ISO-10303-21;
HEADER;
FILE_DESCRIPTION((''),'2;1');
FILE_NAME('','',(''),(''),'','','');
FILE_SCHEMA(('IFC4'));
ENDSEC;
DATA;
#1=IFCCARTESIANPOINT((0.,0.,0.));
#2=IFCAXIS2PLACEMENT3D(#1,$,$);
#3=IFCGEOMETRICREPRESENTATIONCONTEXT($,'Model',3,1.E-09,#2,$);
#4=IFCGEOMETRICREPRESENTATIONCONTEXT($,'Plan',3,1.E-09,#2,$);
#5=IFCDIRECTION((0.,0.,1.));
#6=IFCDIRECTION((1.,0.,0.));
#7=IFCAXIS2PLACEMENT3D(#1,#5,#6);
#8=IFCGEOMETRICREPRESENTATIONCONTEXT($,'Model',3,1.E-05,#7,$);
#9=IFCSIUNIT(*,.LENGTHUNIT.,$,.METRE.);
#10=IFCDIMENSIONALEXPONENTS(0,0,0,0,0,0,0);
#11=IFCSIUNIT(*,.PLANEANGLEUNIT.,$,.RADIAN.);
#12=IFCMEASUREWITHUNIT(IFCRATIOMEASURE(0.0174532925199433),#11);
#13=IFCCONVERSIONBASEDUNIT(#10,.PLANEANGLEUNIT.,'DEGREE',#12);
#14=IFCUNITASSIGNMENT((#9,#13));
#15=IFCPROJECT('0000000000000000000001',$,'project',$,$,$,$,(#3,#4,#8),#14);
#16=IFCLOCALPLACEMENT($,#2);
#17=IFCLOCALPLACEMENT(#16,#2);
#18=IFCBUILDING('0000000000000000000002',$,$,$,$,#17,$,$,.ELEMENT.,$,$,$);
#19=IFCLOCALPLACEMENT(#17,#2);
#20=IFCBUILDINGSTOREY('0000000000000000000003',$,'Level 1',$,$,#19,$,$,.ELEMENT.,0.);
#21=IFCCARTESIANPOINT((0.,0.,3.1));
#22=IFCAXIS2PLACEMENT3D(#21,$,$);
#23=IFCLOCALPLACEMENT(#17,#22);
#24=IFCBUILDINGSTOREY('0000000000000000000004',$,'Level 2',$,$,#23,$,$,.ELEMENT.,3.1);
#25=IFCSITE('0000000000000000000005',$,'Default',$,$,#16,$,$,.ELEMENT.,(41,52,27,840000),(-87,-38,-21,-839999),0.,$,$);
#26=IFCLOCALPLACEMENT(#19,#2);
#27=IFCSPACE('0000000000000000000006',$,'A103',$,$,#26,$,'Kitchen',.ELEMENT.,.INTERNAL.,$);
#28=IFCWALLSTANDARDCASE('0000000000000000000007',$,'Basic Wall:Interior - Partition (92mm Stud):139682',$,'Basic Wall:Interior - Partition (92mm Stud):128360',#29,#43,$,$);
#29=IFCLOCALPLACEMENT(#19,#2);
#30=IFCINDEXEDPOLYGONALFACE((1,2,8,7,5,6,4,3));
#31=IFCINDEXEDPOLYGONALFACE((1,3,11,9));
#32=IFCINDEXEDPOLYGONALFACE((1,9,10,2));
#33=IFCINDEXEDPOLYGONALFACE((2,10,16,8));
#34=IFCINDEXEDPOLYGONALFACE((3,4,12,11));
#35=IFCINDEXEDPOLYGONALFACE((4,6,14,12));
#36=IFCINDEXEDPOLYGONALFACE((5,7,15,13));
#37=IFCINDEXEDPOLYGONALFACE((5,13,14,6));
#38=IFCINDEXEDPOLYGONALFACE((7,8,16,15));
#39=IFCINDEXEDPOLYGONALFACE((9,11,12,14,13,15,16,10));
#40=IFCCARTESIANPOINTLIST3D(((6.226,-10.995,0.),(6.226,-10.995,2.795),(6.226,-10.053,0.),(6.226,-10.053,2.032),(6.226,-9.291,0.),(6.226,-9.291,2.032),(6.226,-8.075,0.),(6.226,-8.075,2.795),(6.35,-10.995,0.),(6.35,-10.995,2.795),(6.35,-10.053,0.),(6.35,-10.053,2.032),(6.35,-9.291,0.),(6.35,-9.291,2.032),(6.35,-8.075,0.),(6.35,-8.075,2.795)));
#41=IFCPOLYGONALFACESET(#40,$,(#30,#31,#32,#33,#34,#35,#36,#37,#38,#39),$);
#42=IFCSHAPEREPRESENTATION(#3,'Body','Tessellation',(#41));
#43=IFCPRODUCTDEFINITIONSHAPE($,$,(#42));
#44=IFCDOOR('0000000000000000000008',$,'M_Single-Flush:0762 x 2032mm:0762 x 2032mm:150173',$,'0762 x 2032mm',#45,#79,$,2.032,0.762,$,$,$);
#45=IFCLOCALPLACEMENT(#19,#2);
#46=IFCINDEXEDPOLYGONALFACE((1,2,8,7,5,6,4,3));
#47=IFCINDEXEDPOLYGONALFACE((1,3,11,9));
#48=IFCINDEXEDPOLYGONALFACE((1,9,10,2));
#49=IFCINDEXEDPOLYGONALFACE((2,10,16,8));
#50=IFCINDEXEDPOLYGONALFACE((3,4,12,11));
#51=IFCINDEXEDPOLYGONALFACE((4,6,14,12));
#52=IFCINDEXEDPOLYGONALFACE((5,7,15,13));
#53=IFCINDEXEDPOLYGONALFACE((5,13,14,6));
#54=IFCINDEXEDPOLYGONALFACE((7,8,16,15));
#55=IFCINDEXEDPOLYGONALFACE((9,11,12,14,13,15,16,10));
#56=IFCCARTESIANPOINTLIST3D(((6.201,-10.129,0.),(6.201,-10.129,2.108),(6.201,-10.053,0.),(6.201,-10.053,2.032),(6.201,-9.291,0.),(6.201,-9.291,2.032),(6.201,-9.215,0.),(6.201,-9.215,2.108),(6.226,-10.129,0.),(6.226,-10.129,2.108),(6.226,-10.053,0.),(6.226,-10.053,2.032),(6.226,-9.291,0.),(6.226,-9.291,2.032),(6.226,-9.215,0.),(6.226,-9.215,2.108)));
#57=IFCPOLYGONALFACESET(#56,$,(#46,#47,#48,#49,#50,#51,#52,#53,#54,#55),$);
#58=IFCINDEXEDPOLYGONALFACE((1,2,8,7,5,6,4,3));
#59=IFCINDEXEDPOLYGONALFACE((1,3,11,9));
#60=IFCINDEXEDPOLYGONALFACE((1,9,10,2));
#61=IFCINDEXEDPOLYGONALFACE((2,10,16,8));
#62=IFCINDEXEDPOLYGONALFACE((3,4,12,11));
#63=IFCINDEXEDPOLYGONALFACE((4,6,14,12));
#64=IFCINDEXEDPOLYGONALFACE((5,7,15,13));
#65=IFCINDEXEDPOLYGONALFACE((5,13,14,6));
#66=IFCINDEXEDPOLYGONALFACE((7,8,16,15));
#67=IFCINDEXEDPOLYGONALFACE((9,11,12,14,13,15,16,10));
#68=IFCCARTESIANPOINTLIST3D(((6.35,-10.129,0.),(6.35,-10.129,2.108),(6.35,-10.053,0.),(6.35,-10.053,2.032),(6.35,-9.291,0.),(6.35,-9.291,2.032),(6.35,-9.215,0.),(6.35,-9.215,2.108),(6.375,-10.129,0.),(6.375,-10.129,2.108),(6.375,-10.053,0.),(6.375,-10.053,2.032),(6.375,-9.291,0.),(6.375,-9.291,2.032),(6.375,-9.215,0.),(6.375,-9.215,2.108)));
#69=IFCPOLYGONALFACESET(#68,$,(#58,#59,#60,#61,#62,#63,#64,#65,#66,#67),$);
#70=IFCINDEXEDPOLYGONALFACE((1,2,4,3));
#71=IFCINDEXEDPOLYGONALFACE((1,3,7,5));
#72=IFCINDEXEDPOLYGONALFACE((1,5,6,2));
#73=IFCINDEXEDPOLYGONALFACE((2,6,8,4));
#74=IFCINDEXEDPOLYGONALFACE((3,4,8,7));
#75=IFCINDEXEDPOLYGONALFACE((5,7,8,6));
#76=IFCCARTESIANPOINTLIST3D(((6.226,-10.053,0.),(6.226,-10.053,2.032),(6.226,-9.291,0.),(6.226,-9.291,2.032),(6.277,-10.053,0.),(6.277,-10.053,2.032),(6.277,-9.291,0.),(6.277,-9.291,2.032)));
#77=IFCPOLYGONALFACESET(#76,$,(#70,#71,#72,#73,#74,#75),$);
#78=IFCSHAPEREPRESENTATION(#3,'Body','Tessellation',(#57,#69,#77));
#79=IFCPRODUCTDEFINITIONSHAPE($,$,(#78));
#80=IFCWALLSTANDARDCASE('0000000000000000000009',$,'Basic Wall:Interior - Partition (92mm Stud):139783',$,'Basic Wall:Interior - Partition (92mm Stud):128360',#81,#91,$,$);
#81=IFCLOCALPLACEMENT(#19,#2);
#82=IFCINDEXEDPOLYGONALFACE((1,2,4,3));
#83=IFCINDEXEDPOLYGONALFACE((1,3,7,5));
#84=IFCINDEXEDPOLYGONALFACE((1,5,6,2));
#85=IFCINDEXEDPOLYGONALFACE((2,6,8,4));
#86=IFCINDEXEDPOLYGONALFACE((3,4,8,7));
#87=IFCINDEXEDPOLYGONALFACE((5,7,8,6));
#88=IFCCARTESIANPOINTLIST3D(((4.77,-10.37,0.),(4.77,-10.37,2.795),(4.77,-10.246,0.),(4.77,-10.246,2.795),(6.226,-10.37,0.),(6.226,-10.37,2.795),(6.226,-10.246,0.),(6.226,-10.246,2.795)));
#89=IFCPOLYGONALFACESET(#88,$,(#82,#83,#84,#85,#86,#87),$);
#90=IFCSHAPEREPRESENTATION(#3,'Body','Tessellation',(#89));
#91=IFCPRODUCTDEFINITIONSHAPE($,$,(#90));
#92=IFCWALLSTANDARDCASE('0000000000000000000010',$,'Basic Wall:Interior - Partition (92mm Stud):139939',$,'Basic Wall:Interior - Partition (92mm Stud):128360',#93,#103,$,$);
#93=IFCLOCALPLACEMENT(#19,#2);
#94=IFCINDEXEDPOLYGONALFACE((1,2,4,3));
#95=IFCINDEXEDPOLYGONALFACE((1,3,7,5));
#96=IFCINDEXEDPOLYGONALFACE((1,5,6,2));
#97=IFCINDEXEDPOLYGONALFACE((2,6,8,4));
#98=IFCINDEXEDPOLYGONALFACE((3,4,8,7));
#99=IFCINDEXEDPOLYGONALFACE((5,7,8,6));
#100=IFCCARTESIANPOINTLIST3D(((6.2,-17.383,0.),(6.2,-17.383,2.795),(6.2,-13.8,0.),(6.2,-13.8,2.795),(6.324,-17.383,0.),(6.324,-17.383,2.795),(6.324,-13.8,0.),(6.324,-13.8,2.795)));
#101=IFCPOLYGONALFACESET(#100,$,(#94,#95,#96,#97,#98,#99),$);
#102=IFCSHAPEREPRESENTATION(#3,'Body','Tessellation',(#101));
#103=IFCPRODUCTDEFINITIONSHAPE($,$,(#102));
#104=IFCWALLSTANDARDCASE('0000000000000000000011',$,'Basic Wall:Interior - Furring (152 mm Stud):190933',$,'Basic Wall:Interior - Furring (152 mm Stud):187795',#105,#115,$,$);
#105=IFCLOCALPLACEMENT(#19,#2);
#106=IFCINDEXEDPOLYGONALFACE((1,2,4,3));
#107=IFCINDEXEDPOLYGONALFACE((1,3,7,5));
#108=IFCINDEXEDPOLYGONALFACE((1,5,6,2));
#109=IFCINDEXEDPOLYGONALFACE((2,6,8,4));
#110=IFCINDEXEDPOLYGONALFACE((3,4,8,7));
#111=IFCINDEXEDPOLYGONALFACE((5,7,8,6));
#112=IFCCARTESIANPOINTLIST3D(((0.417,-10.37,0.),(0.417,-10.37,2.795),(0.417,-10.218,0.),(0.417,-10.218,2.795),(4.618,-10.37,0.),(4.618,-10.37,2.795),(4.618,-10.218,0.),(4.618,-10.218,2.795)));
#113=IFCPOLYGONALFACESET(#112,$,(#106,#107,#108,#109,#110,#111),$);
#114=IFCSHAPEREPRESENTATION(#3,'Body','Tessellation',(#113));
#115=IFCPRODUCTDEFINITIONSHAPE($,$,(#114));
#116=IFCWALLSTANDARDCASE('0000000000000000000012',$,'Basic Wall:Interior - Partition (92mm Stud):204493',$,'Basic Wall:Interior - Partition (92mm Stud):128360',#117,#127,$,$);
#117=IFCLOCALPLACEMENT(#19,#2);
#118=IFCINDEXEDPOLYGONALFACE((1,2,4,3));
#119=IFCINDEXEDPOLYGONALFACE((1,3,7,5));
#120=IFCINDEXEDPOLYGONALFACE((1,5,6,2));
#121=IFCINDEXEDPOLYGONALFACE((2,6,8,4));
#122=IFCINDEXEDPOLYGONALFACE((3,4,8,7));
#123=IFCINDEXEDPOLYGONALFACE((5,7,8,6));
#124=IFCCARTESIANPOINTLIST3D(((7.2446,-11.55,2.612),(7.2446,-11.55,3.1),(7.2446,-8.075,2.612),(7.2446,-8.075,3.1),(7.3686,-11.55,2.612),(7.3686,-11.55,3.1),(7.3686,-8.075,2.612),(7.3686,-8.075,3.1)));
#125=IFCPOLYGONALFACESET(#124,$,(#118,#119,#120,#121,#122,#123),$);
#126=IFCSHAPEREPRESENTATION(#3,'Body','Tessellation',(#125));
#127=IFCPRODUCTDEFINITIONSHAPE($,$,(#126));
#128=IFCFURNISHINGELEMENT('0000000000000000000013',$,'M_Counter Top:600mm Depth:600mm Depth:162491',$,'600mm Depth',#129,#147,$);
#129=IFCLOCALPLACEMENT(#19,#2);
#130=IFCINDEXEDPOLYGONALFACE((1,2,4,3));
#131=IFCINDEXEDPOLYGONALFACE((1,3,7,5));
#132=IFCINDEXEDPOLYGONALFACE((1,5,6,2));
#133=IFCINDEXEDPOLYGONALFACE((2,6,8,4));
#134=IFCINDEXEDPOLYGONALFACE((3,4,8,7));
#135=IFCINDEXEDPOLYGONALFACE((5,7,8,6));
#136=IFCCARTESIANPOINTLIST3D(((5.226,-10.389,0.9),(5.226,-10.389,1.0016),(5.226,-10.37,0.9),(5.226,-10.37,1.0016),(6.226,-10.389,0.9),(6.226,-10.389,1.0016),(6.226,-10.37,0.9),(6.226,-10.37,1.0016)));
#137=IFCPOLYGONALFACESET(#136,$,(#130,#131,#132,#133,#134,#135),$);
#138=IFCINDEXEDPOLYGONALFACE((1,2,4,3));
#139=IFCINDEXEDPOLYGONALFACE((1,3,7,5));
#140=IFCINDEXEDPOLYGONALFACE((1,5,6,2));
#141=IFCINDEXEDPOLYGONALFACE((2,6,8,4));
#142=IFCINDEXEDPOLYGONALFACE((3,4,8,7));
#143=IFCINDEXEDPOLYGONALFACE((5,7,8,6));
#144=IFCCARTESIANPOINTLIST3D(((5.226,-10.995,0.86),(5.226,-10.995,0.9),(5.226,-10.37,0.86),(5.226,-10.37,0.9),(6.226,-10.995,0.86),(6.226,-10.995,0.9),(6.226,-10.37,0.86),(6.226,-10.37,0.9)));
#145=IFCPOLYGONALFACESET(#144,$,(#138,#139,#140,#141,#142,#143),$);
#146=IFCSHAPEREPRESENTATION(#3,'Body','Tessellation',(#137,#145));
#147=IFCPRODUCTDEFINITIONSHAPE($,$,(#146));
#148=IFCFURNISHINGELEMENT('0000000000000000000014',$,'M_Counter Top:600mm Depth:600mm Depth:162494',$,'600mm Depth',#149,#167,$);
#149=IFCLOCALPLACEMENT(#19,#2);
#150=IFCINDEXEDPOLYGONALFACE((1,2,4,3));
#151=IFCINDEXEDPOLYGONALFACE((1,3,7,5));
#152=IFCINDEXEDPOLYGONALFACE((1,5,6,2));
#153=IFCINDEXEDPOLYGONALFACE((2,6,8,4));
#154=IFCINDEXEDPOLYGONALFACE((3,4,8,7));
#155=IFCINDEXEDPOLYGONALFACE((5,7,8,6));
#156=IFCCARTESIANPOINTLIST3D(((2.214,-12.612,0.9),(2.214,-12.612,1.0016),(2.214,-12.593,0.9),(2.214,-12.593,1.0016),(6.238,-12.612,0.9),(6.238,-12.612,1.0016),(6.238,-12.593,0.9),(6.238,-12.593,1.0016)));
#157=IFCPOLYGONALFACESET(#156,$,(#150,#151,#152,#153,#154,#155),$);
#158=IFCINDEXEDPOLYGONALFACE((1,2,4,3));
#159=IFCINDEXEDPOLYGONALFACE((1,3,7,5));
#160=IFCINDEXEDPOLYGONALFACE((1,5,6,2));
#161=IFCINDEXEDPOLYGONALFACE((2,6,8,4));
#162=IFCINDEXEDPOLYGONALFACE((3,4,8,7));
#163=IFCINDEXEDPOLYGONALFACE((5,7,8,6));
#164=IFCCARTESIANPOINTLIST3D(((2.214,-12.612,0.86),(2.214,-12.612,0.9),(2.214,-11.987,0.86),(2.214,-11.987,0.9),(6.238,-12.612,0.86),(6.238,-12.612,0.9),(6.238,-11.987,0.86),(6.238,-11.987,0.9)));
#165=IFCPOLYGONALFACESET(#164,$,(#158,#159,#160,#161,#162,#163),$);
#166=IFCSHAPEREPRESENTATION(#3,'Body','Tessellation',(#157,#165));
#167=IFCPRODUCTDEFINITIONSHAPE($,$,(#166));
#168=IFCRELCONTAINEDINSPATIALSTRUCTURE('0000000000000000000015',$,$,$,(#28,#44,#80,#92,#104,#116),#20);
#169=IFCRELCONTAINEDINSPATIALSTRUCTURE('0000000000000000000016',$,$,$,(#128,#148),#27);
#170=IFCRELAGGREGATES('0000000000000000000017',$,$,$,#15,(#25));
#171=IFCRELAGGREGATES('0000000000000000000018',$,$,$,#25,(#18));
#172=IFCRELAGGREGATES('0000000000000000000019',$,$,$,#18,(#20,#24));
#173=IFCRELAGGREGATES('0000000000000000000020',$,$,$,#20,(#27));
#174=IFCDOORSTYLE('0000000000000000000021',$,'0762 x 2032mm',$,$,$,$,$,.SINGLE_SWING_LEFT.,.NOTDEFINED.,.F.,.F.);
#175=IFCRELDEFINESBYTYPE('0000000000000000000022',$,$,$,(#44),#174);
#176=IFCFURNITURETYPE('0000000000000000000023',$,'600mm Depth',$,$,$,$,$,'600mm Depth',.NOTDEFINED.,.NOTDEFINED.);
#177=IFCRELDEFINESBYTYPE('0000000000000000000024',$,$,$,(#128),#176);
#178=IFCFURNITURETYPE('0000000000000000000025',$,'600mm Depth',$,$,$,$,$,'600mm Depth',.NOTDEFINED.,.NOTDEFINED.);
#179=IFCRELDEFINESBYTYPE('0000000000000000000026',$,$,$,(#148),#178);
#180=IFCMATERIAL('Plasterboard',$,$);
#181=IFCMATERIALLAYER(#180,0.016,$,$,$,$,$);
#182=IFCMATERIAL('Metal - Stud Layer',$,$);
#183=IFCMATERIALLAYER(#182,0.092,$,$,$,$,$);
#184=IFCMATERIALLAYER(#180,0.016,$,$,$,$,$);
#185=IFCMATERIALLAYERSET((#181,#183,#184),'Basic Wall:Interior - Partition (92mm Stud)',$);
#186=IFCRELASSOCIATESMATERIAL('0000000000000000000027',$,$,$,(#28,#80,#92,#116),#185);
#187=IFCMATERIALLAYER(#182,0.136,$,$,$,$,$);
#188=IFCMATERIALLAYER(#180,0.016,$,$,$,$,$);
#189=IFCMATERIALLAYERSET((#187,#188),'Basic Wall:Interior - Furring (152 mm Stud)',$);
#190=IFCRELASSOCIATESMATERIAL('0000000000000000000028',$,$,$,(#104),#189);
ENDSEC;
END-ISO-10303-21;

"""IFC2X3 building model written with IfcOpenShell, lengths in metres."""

from ifc_helpers import new_model, entity, si_unit, converted_unit, frame, frame_2d, origin, origin_with_axes, origin_2d_with_axis, place, context, project, spatial, polyline, rectangle, outline, extrude, source, transform, mapped, material, layer, layer_set, layer_usage, type_object, type_shapes, element, fill, save


model = new_model("IFC2X3")

# Units and contexts
model_context_1 = context("Model", 3, precision=1e-09, world=origin())
plan_context = context("Plan", 3, precision=1e-09, world=origin())
model_context_2 = context("Model", 3, precision=1e-05, world=origin_with_axes())
ifc_project = project(units=[si_unit("LENGTHUNIT", "METRE"), converted_unit("PLANEANGLEUNIT", "DEGREE", entity("IfcRatioMeasure", 0.0174532925199433), si_unit("PLANEANGLEUNIT", "RADIAN"), dimensions=[0, 0, 0, 0, 0, 0, 0])], contexts=[model_context_1, plan_context, model_context_2])

# Site, building, storey
site_placement = place(None, origin())
site = spatial("IfcSite", under=ifc_project, at=site_placement, Name="Default", CompositionType="ELEMENT", RefLatitude=(41, 52, 27, 840000), RefLongitude=(-87, -38, -21, -839999), RefElevation=0.0)
building_placement = place(site_placement, origin())
building = spatial("IfcBuilding", under=site, at=building_placement, CompositionType="ELEMENT")
storey_1_placement = place(building_placement, origin())
storey_1 = spatial("IfcBuildingStorey", under=building, at=storey_1_placement, Name="Level 1", CompositionType="ELEMENT", Elevation=0.0)

# Shared definitions
ifc_material_1 = material(Name="Metal - Stud Layer")
ifc_material_2 = material(Name="Plasterboard")

# Wall, opening, door
ifc_layer_1 = layer(ifc_material_2, 0.016)
ifc_layer_2 = layer(ifc_material_1, 0.092)
ifc_layer_3 = layer(ifc_material_2, 0.016)
ifc_layer_set_1 = layer_set([ifc_layer_1, ifc_layer_2, ifc_layer_3], Name="Basic Wall:Interior - Partition (92mm Stud)")
ifc_layer_usage_1 = layer_usage(ifc_layer_set_1, "AXIS2", "NEGATIVE", 0.062)
wall_1_placement = place(storey_1_placement, frame((6.288, -10.995, 0.0), z_axis=(0.0, 0.0, 1.0), x_axis=(0.0, 1.0, 0.0)))
wall_1 = element("IfcWallStandardCase", 1, at=wall_1_placement, inside=storey_1, material=ifc_layer_usage_1, Name="Basic Wall:Interior - Partition (92mm Stud):139682", ObjectType="Basic Wall:Interior - Partition (92mm Stud):128360", context=model_context_1, shape_type="SweptSolid", body=[
    extrude(rectangle(XDim=2.92, YDim=0.124, at=frame_2d((1.46, 0.0), x_axis=(-1.0, 0.0))), origin(), (0.0, 0.0, 1.0), 2.795),
])
opening_1_placement = place(wall_1_placement, frame((0.942, -0.062, 0.0)))
opening_1 = element("IfcOpeningElement", 2, at=opening_1_placement, cuts=wall_1, ObjectType="Opening", context=model_context_1, shape_type="SweptSolid", body=[
    extrude(rectangle(XDim=0.762, YDim=2.032, at=frame_2d((1.016, 0.381), x_axis=(0.0, -1.0))), frame((0.0, 0.0, 0.0), z_axis=(0.0, 1.0, 0.0), x_axis=(0.0, 0.0, 1.0)), (0.0, 0.0, 1.0), 0.124),
])
door_style_1 = type_object("IfcDoorStyle", Name="0762 x 2032mm", ConstructionType="NOTDEFINED", OperationType="SINGLE_SWING_LEFT", ParameterTakesPrecedence=False, Sizeable=False)
shared_shape_1 = source(origin(), model_context_1, "Body", "SweptSolid", [
    extrude(outline(polyline([(-0.457, -1.073), (0.457, -1.073), (0.457, 1.035), (0.381, 1.035), (0.381, -0.997), (-0.381, -0.997), (-0.381, 1.035), (-0.457, 1.035), (-0.457, -1.073)])), frame((0.381, 0.149, 1.035), z_axis=(0.0, -1.0, 0.0), x_axis=(-1.0, 0.0, 0.0)), (0.0, 0.0, 1.0), 0.025),
    extrude(outline(polyline([(-1.073, -0.457), (1.035, -0.457), (1.035, -0.381), (-0.997, -0.381), (-0.997, 0.381), (1.035, 0.381), (1.035, 0.457), (-1.073, 0.457), (-1.073, -0.457)])), frame((0.381, 0.0, 1.035), z_axis=(0.0, -1.0, 0.0), x_axis=(0.0, 0.0, -1.0)), (0.0, 0.0, 1.0), 0.025),
    extrude(rectangle(XDim=0.762, YDim=0.051, at=origin_2d_with_axis()), frame((0.381, 0.0985, 0.0)), (0.0, 0.0, 1.0), 2.032),
])
type_shapes(door_style_1, [shared_shape_1])
door_1_placement = place(opening_1_placement, origin())
door_1 = element("IfcDoor", 3, at=door_1_placement, inside=storey_1, type_object=door_style_1, Name="M_Single-Flush:0762 x 2032mm:0762 x 2032mm:150173", ObjectType="0762 x 2032mm", OverallHeight=2.032, OverallWidth=0.762, context=model_context_1, shape_type="MappedRepresentation", body=[
    mapped(shared_shape_1, transform((0.0, 0.0, 0.0), scale=1.0)),
])
fill(opening_1, door_1)

# Walls
ifc_layer_usage_2 = layer_usage(ifc_layer_set_1, "AXIS2", "NEGATIVE", 0.062)
wall_2_placement = place(storey_1_placement, frame((4.77, -10.308, 0.0)))
element("IfcWallStandardCase", 4, at=wall_2_placement, inside=storey_1, material=ifc_layer_usage_2, Name="Basic Wall:Interior - Partition (92mm Stud):139783", ObjectType="Basic Wall:Interior - Partition (92mm Stud):128360", context=model_context_1, shape_type="SweptSolid", body=[
    extrude(rectangle(XDim=1.456, YDim=0.124, at=frame_2d((0.728, 0.0), x_axis=(-1.0, 0.0))), origin(), (0.0, 0.0, 1.0), 2.795),
])
ifc_layer_usage_3 = layer_usage(ifc_layer_set_1, "AXIS2", "NEGATIVE", 0.062)
wall_3_placement = place(storey_1_placement, frame((6.262, -13.8, 0.0), z_axis=(0.0, 0.0, 1.0), x_axis=(0.0, -1.0, 0.0)))
element("IfcWallStandardCase", 5, at=wall_3_placement, inside=storey_1, material=ifc_layer_usage_3, Name="Basic Wall:Interior - Partition (92mm Stud):139939", ObjectType="Basic Wall:Interior - Partition (92mm Stud):128360", context=model_context_1, shape_type="SweptSolid", body=[
    extrude(rectangle(XDim=3.583, YDim=0.124, at=frame_2d((1.7915, 0.0), x_axis=(-1.0, 0.0))), origin(), (0.0, 0.0, 1.0), 2.795),
])

# Shared definitions
storey_2_placement = place(building_placement, frame((0.0, 0.0, 3.1)))
storey_2 = spatial("IfcBuildingStorey", under=building, at=storey_2_placement, Name="Level 2", CompositionType="ELEMENT", Elevation=3.1)

# Walls
ifc_layer_4 = layer(ifc_material_1, 0.136)
ifc_layer_5 = layer(ifc_material_2, 0.016)
ifc_layer_set_2 = layer_set([ifc_layer_4, ifc_layer_5], Name="Basic Wall:Interior - Furring (152 mm Stud)")
ifc_layer_usage_4 = layer_usage(ifc_layer_set_2, "AXIS2", "NEGATIVE", 0.076)
wall_4_placement = place(storey_1_placement, frame((0.417, -10.294, 0.0)))
element("IfcWallStandardCase", 6, at=wall_4_placement, inside=storey_1, material=ifc_layer_usage_4, Name="Basic Wall:Interior - Furring (152 mm Stud):190933", ObjectType="Basic Wall:Interior - Furring (152 mm Stud):187795", context=model_context_1, shape_type="SweptSolid", body=[
    extrude(rectangle(XDim=4.201, YDim=0.152, at=frame_2d((2.1005, 0.0), x_axis=(-1.0, 0.0))), origin(), (0.0, 0.0, 1.0), 2.795),
])
ifc_layer_usage_5 = layer_usage(ifc_layer_set_1, "AXIS2", "NEGATIVE", 0.062)
wall_5_placement = place(storey_1_placement, frame((7.3066, -11.55, 2.612), z_axis=(0.0, 0.0, 1.0), x_axis=(0.0, 1.0, 0.0)))
element("IfcWallStandardCase", 7, at=wall_5_placement, inside=storey_1, material=ifc_layer_usage_5, Name="Basic Wall:Interior - Partition (92mm Stud):204493", ObjectType="Basic Wall:Interior - Partition (92mm Stud):128360", context=model_context_1, shape_type="SweptSolid", body=[
    extrude(rectangle(XDim=3.475, YDim=0.124, at=frame_2d((1.7375, 0.0), x_axis=(-1.0, 0.0))), origin(), (0.0, 0.0, 1.0), 0.488),
])

# Shared definitions
space_1_placement = place(storey_1_placement, origin())
space_1 = spatial("IfcSpace", under=storey_1, at=space_1_placement, Name="A103", LongName="Kitchen", CompositionType="ELEMENT", InteriorOrExteriorSpace="INTERNAL")

# Furnishing elements
furniture_type_1 = type_object("IfcFurnitureType", Name="600mm Depth", ElementType="600mm Depth", AssemblyPlace="NOTDEFINED")
shared_shape_2 = source(origin(), model_context_1, "Body", "SweptSolid", [
    extrude(rectangle(XDim=0.0191, YDim=1.0, at=origin_2d_with_axis()), frame((-0.7005, -0.0095, 0.9), z_axis=(0.0, 0.0, 1.0), x_axis=(0.0, -1.0, 0.0)), (0.0, 0.0, 1.0), 0.1016),
    extrude(rectangle(XDim=1.0, YDim=0.625, at=origin_2d_with_axis()), frame((-0.7005, -0.3125, 0.86), z_axis=(0.0, 0.0, 1.0), x_axis=(-1.0, 0.0, 0.0)), (0.0, 0.0, 1.0), 0.04),
])
type_shapes(furniture_type_1, [shared_shape_2])
furnishing_1_placement = place(space_1_placement, frame((6.4265, -10.37, 0.0)))
element("IfcFurnishingElement", 8, at=furnishing_1_placement, inside=space_1, type_object=furniture_type_1, Name="M_Counter Top:600mm Depth:600mm Depth:162491", ObjectType="600mm Depth", context=model_context_1, shape_type="MappedRepresentation", body=[
    mapped(shared_shape_2, transform((0.0, 0.0, 0.0), scale=1.0)),
])
furniture_type_2 = type_object("IfcFurnitureType", Name="600mm Depth", ElementType="600mm Depth", AssemblyPlace="NOTDEFINED")
shared_shape_3 = source(origin(), model_context_1, "Body", "SweptSolid", [
    extrude(rectangle(XDim=0.0191, YDim=4.024, at=origin_2d_with_axis()), frame((0.8115, -0.0095, 0.9), z_axis=(0.0, 0.0, 1.0), x_axis=(0.0, -1.0, 0.0)), (0.0, 0.0, 1.0), 0.1016),
    extrude(rectangle(XDim=4.024, YDim=0.625, at=origin_2d_with_axis()), frame((0.8115, -0.3125, 0.86), z_axis=(0.0, 0.0, 1.0), x_axis=(-1.0, 0.0, 0.0)), (0.0, 0.0, 1.0), 0.04),
])
type_shapes(furniture_type_2, [shared_shape_3])
furnishing_2_placement = place(space_1_placement, frame((5.0375, -12.612, 0.0), z_axis=(0.0, 0.0, 1.0), x_axis=(-1.0, 0.0, 0.0)))
element("IfcFurnishingElement", 9, at=furnishing_2_placement, inside=space_1, type_object=furniture_type_2, Name="M_Counter Top:600mm Depth:600mm Depth:162494", ObjectType="600mm Depth", context=model_context_1, shape_type="MappedRepresentation", body=[
    mapped(shared_shape_3, transform((0.0, 0.0, 0.0), scale=1.0)),
])

save(model, "model.ifc")
